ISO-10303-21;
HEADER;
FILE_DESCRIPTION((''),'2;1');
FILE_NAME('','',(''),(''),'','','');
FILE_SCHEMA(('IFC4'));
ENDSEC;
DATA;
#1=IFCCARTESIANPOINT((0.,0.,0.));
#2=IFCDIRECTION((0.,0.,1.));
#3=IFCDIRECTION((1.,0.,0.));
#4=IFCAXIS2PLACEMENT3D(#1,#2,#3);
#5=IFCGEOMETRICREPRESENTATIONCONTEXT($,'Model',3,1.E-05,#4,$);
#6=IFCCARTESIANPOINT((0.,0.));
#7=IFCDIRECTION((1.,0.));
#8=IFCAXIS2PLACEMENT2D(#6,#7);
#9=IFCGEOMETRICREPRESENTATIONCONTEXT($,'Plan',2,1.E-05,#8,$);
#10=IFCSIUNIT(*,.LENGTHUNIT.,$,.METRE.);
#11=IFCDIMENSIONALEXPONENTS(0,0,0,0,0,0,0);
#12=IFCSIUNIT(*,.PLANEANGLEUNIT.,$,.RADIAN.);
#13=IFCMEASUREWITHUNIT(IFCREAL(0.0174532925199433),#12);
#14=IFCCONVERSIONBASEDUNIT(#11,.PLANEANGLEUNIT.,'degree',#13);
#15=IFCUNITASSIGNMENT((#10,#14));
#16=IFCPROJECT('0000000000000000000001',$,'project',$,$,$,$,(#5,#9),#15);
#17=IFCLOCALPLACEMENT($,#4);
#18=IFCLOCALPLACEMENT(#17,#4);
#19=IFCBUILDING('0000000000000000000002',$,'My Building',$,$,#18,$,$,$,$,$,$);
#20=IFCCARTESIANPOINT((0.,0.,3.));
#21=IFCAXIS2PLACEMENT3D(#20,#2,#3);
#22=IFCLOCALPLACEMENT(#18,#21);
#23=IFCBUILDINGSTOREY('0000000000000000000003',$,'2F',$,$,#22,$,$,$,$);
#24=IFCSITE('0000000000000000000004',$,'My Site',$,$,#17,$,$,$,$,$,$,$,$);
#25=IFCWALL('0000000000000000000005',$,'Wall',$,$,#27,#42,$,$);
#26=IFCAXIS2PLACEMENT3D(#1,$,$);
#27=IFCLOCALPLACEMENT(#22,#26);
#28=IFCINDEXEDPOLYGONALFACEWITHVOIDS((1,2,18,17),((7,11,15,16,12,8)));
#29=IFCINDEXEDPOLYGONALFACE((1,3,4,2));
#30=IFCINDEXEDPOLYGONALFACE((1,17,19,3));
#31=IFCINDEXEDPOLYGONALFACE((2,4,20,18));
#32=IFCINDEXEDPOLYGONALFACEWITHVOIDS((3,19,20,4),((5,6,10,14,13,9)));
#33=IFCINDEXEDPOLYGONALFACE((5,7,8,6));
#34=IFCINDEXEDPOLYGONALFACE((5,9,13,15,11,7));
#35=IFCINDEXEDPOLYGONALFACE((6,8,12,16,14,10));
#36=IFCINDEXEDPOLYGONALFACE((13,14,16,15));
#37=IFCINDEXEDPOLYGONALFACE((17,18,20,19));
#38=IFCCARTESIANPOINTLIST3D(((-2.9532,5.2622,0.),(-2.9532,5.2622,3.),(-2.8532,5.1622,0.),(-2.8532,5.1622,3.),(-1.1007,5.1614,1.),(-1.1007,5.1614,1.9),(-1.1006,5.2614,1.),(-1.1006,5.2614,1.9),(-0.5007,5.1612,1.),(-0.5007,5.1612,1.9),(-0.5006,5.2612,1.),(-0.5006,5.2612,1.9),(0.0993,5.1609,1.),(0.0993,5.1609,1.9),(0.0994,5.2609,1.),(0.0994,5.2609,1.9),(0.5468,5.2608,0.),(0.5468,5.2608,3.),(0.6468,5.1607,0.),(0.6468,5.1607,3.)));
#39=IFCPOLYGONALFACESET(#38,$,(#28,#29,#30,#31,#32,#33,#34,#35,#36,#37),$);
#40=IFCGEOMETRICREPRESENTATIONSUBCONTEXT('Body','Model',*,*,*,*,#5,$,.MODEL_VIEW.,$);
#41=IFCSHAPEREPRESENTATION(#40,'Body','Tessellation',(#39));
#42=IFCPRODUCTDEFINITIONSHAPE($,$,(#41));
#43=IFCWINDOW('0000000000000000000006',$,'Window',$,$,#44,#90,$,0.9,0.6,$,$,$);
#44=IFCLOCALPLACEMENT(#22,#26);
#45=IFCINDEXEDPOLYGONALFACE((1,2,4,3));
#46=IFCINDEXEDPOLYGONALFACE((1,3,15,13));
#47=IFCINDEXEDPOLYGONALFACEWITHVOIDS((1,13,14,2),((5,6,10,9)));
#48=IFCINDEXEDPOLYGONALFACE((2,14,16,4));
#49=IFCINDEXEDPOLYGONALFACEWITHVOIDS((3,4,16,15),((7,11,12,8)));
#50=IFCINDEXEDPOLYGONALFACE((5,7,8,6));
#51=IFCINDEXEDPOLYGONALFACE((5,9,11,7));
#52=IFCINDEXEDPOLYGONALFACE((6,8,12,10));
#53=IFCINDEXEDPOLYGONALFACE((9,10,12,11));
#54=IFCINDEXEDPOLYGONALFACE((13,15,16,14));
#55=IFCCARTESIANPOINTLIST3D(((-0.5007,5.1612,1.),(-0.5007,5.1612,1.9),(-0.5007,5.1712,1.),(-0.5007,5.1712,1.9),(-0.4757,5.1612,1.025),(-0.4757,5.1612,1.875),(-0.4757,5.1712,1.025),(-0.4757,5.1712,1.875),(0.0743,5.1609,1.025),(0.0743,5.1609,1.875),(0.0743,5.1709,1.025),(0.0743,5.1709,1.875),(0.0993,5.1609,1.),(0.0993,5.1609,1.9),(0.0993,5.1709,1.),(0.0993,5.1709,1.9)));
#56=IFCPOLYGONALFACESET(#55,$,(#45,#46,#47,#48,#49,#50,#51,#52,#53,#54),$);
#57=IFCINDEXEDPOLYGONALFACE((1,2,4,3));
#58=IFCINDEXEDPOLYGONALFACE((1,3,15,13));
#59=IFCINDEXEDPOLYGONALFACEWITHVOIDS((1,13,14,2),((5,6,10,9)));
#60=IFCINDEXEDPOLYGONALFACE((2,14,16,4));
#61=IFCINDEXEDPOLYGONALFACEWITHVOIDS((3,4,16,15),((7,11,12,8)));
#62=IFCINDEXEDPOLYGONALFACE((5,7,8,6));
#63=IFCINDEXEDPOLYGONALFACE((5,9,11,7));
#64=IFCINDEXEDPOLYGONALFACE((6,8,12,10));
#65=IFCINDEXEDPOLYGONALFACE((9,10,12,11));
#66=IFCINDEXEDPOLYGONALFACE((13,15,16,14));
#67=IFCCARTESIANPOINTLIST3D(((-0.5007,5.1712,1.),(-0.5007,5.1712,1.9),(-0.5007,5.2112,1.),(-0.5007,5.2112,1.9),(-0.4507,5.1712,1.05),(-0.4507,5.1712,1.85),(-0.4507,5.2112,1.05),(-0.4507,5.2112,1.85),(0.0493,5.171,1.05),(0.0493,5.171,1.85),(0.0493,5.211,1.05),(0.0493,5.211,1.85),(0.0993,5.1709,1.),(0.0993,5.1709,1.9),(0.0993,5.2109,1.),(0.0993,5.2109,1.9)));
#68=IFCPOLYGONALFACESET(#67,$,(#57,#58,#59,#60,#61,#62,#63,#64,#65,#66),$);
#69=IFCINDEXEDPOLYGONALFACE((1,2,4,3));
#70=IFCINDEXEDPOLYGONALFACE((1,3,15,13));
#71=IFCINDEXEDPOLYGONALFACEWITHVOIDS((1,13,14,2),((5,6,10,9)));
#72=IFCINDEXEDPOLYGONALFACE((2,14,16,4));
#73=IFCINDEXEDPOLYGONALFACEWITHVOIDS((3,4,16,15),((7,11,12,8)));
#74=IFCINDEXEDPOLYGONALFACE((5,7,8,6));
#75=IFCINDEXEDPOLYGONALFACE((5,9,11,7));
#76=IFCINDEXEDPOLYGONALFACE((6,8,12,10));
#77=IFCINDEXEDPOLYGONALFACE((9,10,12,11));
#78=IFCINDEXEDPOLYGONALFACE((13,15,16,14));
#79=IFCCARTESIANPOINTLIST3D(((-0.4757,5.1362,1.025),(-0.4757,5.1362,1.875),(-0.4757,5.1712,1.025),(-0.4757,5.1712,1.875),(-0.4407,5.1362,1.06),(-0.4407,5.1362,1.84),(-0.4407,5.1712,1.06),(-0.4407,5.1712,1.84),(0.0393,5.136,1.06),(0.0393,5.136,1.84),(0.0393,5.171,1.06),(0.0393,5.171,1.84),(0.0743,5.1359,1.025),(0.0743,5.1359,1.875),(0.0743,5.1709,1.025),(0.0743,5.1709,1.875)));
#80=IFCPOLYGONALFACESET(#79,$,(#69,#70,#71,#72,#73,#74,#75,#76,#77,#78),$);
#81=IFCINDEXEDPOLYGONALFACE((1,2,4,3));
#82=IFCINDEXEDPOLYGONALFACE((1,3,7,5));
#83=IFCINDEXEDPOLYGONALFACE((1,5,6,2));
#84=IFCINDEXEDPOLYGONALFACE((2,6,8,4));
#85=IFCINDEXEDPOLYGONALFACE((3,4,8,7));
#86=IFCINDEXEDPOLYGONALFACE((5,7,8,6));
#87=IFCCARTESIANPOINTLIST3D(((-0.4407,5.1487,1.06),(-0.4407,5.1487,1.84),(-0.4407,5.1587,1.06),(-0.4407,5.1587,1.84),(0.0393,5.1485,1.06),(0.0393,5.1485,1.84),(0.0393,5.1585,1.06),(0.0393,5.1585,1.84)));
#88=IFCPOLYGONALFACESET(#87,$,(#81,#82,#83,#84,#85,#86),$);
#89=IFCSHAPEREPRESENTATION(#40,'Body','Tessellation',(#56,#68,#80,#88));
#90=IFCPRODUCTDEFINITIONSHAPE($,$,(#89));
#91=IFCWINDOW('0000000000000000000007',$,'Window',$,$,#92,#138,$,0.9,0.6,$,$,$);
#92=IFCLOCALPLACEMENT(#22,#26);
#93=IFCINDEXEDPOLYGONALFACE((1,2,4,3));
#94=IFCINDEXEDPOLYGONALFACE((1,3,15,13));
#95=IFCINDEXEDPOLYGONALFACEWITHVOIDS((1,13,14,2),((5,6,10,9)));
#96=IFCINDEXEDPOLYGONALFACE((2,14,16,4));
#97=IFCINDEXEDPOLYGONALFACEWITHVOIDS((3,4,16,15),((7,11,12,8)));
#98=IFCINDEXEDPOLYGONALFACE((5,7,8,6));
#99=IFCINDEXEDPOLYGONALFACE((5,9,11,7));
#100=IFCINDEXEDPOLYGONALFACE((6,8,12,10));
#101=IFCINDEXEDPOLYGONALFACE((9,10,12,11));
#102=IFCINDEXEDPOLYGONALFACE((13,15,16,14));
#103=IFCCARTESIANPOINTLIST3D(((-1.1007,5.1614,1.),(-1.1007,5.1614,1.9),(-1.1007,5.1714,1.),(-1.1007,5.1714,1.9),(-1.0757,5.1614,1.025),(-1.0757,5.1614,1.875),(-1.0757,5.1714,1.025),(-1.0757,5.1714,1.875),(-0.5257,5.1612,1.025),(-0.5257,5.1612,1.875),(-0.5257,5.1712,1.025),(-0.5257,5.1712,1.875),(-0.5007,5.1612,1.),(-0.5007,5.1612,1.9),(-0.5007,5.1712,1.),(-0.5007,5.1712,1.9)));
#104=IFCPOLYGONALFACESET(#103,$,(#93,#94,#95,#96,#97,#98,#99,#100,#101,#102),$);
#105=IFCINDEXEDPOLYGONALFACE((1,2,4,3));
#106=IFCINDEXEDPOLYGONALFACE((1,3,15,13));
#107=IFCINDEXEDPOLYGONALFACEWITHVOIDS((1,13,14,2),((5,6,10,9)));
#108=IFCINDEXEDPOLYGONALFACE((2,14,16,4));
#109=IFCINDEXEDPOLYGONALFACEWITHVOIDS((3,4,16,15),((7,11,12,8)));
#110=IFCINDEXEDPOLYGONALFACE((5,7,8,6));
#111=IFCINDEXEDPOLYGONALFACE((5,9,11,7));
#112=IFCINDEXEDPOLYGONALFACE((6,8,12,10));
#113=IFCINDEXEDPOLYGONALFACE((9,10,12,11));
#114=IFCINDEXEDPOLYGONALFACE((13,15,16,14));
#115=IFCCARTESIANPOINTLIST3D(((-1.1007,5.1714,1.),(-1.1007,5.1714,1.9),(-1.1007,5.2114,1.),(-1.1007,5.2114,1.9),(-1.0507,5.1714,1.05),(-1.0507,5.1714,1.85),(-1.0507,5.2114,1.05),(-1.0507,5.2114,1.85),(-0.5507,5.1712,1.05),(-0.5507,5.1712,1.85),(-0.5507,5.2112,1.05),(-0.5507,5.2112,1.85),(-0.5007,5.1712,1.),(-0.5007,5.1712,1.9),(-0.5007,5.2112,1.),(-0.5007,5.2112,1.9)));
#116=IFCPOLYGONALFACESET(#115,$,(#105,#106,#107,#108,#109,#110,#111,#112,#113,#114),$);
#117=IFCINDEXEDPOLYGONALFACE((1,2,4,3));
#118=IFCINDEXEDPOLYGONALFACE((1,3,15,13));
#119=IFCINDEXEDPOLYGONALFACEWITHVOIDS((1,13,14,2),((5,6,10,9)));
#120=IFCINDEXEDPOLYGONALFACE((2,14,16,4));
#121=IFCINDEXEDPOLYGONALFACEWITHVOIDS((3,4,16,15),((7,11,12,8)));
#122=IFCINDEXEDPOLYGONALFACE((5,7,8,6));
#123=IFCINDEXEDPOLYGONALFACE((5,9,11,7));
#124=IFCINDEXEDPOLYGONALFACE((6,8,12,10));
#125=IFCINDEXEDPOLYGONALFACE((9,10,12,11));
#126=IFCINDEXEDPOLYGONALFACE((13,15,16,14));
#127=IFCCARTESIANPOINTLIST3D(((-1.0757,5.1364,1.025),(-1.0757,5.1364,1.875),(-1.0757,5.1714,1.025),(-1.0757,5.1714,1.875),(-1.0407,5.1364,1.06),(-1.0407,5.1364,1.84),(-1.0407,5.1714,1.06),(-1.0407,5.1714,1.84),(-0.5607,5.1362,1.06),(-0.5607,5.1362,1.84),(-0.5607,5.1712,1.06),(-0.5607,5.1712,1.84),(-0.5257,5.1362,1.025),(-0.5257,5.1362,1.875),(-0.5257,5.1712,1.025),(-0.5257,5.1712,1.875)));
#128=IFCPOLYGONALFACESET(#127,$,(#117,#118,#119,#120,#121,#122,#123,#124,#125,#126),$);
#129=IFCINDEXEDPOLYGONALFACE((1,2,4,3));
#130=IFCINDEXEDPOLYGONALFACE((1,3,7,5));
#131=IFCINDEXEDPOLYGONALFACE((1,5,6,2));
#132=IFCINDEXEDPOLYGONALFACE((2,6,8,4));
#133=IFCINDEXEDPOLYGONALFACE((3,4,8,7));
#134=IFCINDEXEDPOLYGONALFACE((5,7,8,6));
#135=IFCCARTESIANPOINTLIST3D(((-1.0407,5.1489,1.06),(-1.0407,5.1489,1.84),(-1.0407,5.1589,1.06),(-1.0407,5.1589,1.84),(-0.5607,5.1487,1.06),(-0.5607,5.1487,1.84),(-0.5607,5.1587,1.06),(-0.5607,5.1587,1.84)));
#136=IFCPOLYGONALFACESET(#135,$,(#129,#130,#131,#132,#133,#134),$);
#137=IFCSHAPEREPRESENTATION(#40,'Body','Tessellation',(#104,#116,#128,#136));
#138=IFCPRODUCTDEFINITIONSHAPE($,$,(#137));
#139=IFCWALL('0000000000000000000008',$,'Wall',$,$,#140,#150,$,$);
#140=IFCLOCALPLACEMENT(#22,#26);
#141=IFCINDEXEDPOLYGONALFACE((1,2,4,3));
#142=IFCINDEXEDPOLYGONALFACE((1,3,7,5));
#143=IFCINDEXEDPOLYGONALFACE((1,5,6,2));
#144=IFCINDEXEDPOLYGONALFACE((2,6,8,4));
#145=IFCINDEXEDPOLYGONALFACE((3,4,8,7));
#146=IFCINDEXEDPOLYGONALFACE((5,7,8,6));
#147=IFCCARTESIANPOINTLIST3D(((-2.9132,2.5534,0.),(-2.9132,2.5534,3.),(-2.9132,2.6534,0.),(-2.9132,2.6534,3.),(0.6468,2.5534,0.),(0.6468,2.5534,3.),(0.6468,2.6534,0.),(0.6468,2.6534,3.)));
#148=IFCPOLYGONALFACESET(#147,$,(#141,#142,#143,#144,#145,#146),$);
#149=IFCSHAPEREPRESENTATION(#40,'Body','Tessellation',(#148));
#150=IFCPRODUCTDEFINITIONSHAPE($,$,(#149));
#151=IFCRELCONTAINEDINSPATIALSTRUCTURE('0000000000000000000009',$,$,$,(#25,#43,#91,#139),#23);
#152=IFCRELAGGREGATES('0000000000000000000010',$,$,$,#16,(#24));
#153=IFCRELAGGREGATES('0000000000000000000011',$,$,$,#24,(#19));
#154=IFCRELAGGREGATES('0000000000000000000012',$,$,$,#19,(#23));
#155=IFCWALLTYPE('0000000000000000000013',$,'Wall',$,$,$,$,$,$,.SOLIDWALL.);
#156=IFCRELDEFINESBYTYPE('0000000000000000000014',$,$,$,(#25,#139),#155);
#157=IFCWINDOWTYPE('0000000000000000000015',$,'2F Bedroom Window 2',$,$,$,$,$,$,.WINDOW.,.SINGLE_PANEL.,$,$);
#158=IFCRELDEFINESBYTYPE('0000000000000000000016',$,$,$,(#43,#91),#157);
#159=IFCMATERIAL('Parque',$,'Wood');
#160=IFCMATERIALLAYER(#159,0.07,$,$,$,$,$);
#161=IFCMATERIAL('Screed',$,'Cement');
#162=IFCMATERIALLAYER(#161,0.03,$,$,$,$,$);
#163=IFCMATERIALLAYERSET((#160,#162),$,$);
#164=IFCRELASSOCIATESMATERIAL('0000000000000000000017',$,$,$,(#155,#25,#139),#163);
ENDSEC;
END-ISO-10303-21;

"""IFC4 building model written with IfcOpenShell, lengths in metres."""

from ifc_helpers import new_model, entity, si_unit, converted_unit, frame, origin_with_axes, origin_2d_with_axis, place, context, subcontext, project, spatial, line, indexed_curve, outline, extrude, shape, source, transform, mapped, material, layer, layer_set, layer_usage, type_object, type_shapes, element, fill, save


model = new_model("IFC4")

# Units and contexts
model_context = context("Model", 3, precision=1e-05, world=origin_with_axes())
plan_context = context("Plan", 2, precision=1e-05, world=origin_2d_with_axis())
body_context_1 = subcontext(model_context, "Body", "Model", "MODEL_VIEW")
body_context_2 = subcontext(plan_context, "Body", "Plan", "PLAN_VIEW")
ifc_project = project(units=[si_unit("LENGTHUNIT", "METRE"), converted_unit("PLANEANGLEUNIT", "degree", entity("IfcReal", 0.0174532925199433), si_unit("PLANEANGLEUNIT", "RADIAN"), dimensions=[0, 0, 0, 0, 0, 0, 0])], contexts=[model_context, plan_context])

# Site, building, storey
site_placement = place(None, origin_with_axes())
site = spatial("IfcSite", under=ifc_project, at=site_placement, Name="My Site")
building_placement = place(site_placement, origin_with_axes())
building = spatial("IfcBuilding", under=site, at=building_placement, Name="My Building")
storey_placement = place(building_placement, frame((0.0, 0.0, 3.0), z_axis=(0.0, 0.0, 1.0), x_axis=(1.0, 0.0, 0.0)))
storey = spatial("IfcBuildingStorey", under=building, at=storey_placement, Name="2F")

# Shared definitions
ifc_material_1 = material(Name="Parque", Category="Wood")
ifc_layer_1 = layer(ifc_material_1, 0.07)
ifc_material_2 = material(Name="Screed", Category="Cement")
ifc_layer_2 = layer(ifc_material_2, 0.03)
ifc_layer_set = layer_set([ifc_layer_1, ifc_layer_2])
wall_type = type_object("IfcWallType", Name="Wall", PredefinedType="SOLIDWALL", material=ifc_layer_set)

# Wall, openings, windows
ifc_layer_usage_1 = layer_usage(ifc_layer_set, "AXIS2", "POSITIVE", 0.0)
wall_1_placement = place(storey_placement, frame((0.5468, 5.2608, 0.0), z_axis=(0.0, 0.0, 1.0), x_axis=(-1.0, 0.000416, 0.0)))
wall_1 = element("IfcWall", 1, at=wall_1_placement, inside=storey, type_object=wall_type, material=ifc_layer_usage_1, Name="Wall", context=body_context_1, shape_type="SweptSolid", body=[
    extrude(outline(indexed_curve([(0.0, 0.0), (-0.1, 0.1), (3.4, 0.1), (3.5, 0.0)], segments=[line(1, 2, 3, 4, 1)])), origin_with_axes(), (0.0, 0.0, 1.0), 3.0),
])
shared_shape_1 = source(origin_with_axes(), body_context_1, "Body", "SweptSolid", [
    extrude(outline(indexed_curve([(0.0, 0.0), (0.6, 0.0), (0.6, 0.9), (0.0, 0.9)], segments=[line(1, 2, 3, 4, 1)])), frame((0.0, -0.6, 0.0), z_axis=(0.0, -1.0, 0.0), x_axis=(1.0, 0.0, 0.0)), (0.0, 0.0, -1.0), 1.2),
])
opening_1_placement = place(wall_1_placement, frame((0.4475, 0.0, 1.0), z_axis=(0.0, 0.0, 1.0), x_axis=(1.0, 0.0, 0.0)))
opening_1 = element("IfcOpeningElement", 2, at=opening_1_placement, cuts=wall_1, PredefinedType="OPENING", context=body_context_1, shape_type="MappedRepresentation", body=[
    mapped(shared_shape_1, transform((0.0, 0.0, 0.0), x_axis=(1.0, 0.0, 0.0), y_axis=(0.0, 1.0, 0.0), z_axis=(0.0, 0.0, 1.0), scale=1.0)),
])
opening_2_placement = place(wall_1_placement, frame((1.0475, 0.0, 1.0), z_axis=(0.0, 0.0, 1.0), x_axis=(1.0, 0.0, 0.0)))
opening_2 = element("IfcOpeningElement", 3, at=opening_2_placement, cuts=wall_1, PredefinedType="OPENING", context=body_context_1, shape_type="MappedRepresentation", body=[
    mapped(shared_shape_1, transform((0.0, 0.0, 0.0), x_axis=(1.0, 0.0, 0.0), y_axis=(0.0, 1.0, 0.0), z_axis=(0.0, 0.0, 1.0), scale=1.0)),
])
window_type_1 = type_object("IfcWindowType", Name="2F Bedroom Window 2", PartitioningType="SINGLE_PANEL", PredefinedType="WINDOW")
shared_shape_2 = source(origin_with_axes(), body_context_1, "Body", "SweptSolid", [
    extrude(outline(indexed_curve([(0.0, 0.0), (0.6, 0.0), (0.6, 0.9), (0.0, 0.9)], segments=[line(1, 2, 3, 4, 1)]), holes=[indexed_curve([(0.025, 0.025), (0.575, 0.025), (0.575, 0.875), (0.025, 0.875)], segments=[line(1, 2, 3, 4, 1)])]), frame((0.0, 0.09, 0.0), z_axis=(0.0, -1.0, 0.0), x_axis=(1.0, 0.0, 0.0)), (0.0, 0.0, -1.0), 0.01),
    extrude(outline(indexed_curve([(0.0, 0.0), (0.6, 0.0), (0.6, 0.9), (0.0, 0.9)], segments=[line(1, 2, 3, 4, 1)]), holes=[indexed_curve([(0.05, 0.05), (0.55, 0.05), (0.55, 0.85), (0.05, 0.85)], segments=[line(1, 2, 3, 4, 1)])]), frame((0.0, 0.05, 0.0), z_axis=(0.0, -1.0, 0.0), x_axis=(1.0, 0.0, 0.0)), (0.0, 0.0, -1.0), 0.04),
    extrude(outline(indexed_curve([(0.0, 0.0), (0.55, 0.0), (0.55, 0.85), (0.0, 0.85)], segments=[line(1, 2, 3, 4, 1)]), holes=[indexed_curve([(0.035, 0.035), (0.515, 0.035), (0.515, 0.815), (0.035, 0.815)], segments=[line(1, 2, 3, 4, 1)])]), frame((0.025, 0.09, 0.025), z_axis=(0.0, -1.0, 0.0), x_axis=(1.0, 0.0, 0.0)), (0.0, 0.0, -1.0), 0.035),
    extrude(outline(indexed_curve([(0.035, 0.035), (0.515, 0.035), (0.515, 0.815), (0.035, 0.815)], segments=[line(1, 2, 3, 4, 1)])), frame((0.025, 0.1025, 0.025), z_axis=(0.0, -1.0, 0.0), x_axis=(1.0, 0.0, 0.0)), (0.0, 0.0, -1.0), 0.01),
])
shared_shape_3 = source(origin_with_axes(), body_context_2, "Body", "Curve2D", [
    entity("IfcIndexedPolyCurve", entity("IfcCartesianPointList2D", [[0.05, 0.05], [0.55, 0.05]])),
    entity("IfcIndexedPolyCurve", entity("IfcCartesianPointList2D", [[0.0, 0.1], [0.025, 0.1], [0.025, 0.09], [0.05, 0.09], [0.05, 0.05], [0.0, 0.05]]), [entity("IfcLineIndex", [1, 2, 3, 4, 5, 6, 1])]),
    entity("IfcIndexedPolyCurve", entity("IfcCartesianPointList2D", [[0.6, 0.1], [0.575, 0.1], [0.575, 0.09], [0.55, 0.09], [0.55, 0.05], [0.6, 0.05]]), [entity("IfcLineIndex", [1, 2, 3, 4, 5, 6, 1])]),
    entity("IfcIndexedPolyCurve", entity("IfcCartesianPointList2D", [[0.025, 0.09], [0.06, 0.09], [0.06, 0.125], [0.025, 0.125]]), [entity("IfcLineIndex", [1, 2, 3, 4, 1])]),
    entity("IfcIndexedPolyCurve", entity("IfcCartesianPointList2D", [[0.575, 0.09], [0.54, 0.09], [0.54, 0.125], [0.575, 0.125]]), [entity("IfcLineIndex", [1, 2, 3, 4, 1])]),
    entity("IfcIndexedPolyCurve", entity("IfcCartesianPointList2D", [[0.06, 0.09], [0.54, 0.09]])),
    entity("IfcIndexedPolyCurve", entity("IfcCartesianPointList2D", [[0.06, 0.125], [0.54, 0.125]])),
    entity("IfcIndexedPolyCurve", entity("IfcCartesianPointList2D", [[0.06, 0.1075], [0.54, 0.1075]])),
])
type_shapes(window_type_1, [shared_shape_2, shared_shape_3])
window_1_placement = place(opening_1_placement, frame((0.0, 0.0, 0.0), z_axis=(0.0, 0.0, 1.0), x_axis=(1.0, 0.0, 0.0)))
window_1 = element("IfcWindow", 4, at=window_1_placement, inside=storey, type_object=window_type_1, Name="Window", OverallHeight=0.9, OverallWidth=0.6, shapes=[
    shape(body_context_1, "Body", "MappedRepresentation", [mapped(shared_shape_2, transform((0.0, 0.0, 0.0), x_axis=(1.0, 0.0, 0.0), y_axis=(0.0, 1.0, 0.0), z_axis=(0.0, 0.0, 1.0), scale=1.0))]),
    shape(body_context_2, "Body", "MappedRepresentation", [mapped(shared_shape_3, transform((0.0, 0.0, 0.0), x_axis=(1.0, 0.0, 0.0), y_axis=(0.0, 1.0, 0.0), z_axis=(0.0, 0.0, 1.0), scale=1.0))]),
])
fill(opening_1, window_1)
window_2_placement = place(opening_2_placement, frame((0.0, 0.0, 0.0), z_axis=(0.0, 0.0, 1.0), x_axis=(1.0, 0.0, 0.0)))
window_2 = element("IfcWindow", 5, at=window_2_placement, inside=storey, type_object=window_type_1, Name="Window", OverallHeight=0.9, OverallWidth=0.6, shapes=[
    shape(body_context_1, "Body", "MappedRepresentation", [mapped(shared_shape_2, transform((0.0, 0.0, 0.0), x_axis=(1.0, 0.0, 0.0), y_axis=(0.0, 1.0, 0.0), z_axis=(0.0, 0.0, 1.0), scale=1.0))]),
    shape(body_context_2, "Body", "MappedRepresentation", [mapped(shared_shape_3, transform((0.0, 0.0, 0.0), x_axis=(1.0, 0.0, 0.0), y_axis=(0.0, 1.0, 0.0), z_axis=(0.0, 0.0, 1.0), scale=1.0))]),
])
fill(opening_2, window_2)

# Wall
ifc_layer_usage_2 = layer_usage(ifc_layer_set, "AXIS2", "POSITIVE", 0.0)
wall_2_placement = place(storey_placement, frame((-2.9132, 2.5534, 0.0), z_axis=(0.0, 0.0, 1.0), x_axis=(1.0, 0.0, 0.0)))
element("IfcWall", 6, at=wall_2_placement, inside=storey, type_object=wall_type, material=ifc_layer_usage_2, Name="Wall", context=body_context_1, shape_type="SweptSolid", body=[
    extrude(outline(indexed_curve([(0.0, 0.0), (0.0, 0.1), (3.56, 0.1), (3.56, 0.0)], segments=[line(1, 2, 3, 4, 1)])), origin_with_axes(), (0.0, 0.0, 1.0), 3.0),
])

save(model, "model.ifc")
